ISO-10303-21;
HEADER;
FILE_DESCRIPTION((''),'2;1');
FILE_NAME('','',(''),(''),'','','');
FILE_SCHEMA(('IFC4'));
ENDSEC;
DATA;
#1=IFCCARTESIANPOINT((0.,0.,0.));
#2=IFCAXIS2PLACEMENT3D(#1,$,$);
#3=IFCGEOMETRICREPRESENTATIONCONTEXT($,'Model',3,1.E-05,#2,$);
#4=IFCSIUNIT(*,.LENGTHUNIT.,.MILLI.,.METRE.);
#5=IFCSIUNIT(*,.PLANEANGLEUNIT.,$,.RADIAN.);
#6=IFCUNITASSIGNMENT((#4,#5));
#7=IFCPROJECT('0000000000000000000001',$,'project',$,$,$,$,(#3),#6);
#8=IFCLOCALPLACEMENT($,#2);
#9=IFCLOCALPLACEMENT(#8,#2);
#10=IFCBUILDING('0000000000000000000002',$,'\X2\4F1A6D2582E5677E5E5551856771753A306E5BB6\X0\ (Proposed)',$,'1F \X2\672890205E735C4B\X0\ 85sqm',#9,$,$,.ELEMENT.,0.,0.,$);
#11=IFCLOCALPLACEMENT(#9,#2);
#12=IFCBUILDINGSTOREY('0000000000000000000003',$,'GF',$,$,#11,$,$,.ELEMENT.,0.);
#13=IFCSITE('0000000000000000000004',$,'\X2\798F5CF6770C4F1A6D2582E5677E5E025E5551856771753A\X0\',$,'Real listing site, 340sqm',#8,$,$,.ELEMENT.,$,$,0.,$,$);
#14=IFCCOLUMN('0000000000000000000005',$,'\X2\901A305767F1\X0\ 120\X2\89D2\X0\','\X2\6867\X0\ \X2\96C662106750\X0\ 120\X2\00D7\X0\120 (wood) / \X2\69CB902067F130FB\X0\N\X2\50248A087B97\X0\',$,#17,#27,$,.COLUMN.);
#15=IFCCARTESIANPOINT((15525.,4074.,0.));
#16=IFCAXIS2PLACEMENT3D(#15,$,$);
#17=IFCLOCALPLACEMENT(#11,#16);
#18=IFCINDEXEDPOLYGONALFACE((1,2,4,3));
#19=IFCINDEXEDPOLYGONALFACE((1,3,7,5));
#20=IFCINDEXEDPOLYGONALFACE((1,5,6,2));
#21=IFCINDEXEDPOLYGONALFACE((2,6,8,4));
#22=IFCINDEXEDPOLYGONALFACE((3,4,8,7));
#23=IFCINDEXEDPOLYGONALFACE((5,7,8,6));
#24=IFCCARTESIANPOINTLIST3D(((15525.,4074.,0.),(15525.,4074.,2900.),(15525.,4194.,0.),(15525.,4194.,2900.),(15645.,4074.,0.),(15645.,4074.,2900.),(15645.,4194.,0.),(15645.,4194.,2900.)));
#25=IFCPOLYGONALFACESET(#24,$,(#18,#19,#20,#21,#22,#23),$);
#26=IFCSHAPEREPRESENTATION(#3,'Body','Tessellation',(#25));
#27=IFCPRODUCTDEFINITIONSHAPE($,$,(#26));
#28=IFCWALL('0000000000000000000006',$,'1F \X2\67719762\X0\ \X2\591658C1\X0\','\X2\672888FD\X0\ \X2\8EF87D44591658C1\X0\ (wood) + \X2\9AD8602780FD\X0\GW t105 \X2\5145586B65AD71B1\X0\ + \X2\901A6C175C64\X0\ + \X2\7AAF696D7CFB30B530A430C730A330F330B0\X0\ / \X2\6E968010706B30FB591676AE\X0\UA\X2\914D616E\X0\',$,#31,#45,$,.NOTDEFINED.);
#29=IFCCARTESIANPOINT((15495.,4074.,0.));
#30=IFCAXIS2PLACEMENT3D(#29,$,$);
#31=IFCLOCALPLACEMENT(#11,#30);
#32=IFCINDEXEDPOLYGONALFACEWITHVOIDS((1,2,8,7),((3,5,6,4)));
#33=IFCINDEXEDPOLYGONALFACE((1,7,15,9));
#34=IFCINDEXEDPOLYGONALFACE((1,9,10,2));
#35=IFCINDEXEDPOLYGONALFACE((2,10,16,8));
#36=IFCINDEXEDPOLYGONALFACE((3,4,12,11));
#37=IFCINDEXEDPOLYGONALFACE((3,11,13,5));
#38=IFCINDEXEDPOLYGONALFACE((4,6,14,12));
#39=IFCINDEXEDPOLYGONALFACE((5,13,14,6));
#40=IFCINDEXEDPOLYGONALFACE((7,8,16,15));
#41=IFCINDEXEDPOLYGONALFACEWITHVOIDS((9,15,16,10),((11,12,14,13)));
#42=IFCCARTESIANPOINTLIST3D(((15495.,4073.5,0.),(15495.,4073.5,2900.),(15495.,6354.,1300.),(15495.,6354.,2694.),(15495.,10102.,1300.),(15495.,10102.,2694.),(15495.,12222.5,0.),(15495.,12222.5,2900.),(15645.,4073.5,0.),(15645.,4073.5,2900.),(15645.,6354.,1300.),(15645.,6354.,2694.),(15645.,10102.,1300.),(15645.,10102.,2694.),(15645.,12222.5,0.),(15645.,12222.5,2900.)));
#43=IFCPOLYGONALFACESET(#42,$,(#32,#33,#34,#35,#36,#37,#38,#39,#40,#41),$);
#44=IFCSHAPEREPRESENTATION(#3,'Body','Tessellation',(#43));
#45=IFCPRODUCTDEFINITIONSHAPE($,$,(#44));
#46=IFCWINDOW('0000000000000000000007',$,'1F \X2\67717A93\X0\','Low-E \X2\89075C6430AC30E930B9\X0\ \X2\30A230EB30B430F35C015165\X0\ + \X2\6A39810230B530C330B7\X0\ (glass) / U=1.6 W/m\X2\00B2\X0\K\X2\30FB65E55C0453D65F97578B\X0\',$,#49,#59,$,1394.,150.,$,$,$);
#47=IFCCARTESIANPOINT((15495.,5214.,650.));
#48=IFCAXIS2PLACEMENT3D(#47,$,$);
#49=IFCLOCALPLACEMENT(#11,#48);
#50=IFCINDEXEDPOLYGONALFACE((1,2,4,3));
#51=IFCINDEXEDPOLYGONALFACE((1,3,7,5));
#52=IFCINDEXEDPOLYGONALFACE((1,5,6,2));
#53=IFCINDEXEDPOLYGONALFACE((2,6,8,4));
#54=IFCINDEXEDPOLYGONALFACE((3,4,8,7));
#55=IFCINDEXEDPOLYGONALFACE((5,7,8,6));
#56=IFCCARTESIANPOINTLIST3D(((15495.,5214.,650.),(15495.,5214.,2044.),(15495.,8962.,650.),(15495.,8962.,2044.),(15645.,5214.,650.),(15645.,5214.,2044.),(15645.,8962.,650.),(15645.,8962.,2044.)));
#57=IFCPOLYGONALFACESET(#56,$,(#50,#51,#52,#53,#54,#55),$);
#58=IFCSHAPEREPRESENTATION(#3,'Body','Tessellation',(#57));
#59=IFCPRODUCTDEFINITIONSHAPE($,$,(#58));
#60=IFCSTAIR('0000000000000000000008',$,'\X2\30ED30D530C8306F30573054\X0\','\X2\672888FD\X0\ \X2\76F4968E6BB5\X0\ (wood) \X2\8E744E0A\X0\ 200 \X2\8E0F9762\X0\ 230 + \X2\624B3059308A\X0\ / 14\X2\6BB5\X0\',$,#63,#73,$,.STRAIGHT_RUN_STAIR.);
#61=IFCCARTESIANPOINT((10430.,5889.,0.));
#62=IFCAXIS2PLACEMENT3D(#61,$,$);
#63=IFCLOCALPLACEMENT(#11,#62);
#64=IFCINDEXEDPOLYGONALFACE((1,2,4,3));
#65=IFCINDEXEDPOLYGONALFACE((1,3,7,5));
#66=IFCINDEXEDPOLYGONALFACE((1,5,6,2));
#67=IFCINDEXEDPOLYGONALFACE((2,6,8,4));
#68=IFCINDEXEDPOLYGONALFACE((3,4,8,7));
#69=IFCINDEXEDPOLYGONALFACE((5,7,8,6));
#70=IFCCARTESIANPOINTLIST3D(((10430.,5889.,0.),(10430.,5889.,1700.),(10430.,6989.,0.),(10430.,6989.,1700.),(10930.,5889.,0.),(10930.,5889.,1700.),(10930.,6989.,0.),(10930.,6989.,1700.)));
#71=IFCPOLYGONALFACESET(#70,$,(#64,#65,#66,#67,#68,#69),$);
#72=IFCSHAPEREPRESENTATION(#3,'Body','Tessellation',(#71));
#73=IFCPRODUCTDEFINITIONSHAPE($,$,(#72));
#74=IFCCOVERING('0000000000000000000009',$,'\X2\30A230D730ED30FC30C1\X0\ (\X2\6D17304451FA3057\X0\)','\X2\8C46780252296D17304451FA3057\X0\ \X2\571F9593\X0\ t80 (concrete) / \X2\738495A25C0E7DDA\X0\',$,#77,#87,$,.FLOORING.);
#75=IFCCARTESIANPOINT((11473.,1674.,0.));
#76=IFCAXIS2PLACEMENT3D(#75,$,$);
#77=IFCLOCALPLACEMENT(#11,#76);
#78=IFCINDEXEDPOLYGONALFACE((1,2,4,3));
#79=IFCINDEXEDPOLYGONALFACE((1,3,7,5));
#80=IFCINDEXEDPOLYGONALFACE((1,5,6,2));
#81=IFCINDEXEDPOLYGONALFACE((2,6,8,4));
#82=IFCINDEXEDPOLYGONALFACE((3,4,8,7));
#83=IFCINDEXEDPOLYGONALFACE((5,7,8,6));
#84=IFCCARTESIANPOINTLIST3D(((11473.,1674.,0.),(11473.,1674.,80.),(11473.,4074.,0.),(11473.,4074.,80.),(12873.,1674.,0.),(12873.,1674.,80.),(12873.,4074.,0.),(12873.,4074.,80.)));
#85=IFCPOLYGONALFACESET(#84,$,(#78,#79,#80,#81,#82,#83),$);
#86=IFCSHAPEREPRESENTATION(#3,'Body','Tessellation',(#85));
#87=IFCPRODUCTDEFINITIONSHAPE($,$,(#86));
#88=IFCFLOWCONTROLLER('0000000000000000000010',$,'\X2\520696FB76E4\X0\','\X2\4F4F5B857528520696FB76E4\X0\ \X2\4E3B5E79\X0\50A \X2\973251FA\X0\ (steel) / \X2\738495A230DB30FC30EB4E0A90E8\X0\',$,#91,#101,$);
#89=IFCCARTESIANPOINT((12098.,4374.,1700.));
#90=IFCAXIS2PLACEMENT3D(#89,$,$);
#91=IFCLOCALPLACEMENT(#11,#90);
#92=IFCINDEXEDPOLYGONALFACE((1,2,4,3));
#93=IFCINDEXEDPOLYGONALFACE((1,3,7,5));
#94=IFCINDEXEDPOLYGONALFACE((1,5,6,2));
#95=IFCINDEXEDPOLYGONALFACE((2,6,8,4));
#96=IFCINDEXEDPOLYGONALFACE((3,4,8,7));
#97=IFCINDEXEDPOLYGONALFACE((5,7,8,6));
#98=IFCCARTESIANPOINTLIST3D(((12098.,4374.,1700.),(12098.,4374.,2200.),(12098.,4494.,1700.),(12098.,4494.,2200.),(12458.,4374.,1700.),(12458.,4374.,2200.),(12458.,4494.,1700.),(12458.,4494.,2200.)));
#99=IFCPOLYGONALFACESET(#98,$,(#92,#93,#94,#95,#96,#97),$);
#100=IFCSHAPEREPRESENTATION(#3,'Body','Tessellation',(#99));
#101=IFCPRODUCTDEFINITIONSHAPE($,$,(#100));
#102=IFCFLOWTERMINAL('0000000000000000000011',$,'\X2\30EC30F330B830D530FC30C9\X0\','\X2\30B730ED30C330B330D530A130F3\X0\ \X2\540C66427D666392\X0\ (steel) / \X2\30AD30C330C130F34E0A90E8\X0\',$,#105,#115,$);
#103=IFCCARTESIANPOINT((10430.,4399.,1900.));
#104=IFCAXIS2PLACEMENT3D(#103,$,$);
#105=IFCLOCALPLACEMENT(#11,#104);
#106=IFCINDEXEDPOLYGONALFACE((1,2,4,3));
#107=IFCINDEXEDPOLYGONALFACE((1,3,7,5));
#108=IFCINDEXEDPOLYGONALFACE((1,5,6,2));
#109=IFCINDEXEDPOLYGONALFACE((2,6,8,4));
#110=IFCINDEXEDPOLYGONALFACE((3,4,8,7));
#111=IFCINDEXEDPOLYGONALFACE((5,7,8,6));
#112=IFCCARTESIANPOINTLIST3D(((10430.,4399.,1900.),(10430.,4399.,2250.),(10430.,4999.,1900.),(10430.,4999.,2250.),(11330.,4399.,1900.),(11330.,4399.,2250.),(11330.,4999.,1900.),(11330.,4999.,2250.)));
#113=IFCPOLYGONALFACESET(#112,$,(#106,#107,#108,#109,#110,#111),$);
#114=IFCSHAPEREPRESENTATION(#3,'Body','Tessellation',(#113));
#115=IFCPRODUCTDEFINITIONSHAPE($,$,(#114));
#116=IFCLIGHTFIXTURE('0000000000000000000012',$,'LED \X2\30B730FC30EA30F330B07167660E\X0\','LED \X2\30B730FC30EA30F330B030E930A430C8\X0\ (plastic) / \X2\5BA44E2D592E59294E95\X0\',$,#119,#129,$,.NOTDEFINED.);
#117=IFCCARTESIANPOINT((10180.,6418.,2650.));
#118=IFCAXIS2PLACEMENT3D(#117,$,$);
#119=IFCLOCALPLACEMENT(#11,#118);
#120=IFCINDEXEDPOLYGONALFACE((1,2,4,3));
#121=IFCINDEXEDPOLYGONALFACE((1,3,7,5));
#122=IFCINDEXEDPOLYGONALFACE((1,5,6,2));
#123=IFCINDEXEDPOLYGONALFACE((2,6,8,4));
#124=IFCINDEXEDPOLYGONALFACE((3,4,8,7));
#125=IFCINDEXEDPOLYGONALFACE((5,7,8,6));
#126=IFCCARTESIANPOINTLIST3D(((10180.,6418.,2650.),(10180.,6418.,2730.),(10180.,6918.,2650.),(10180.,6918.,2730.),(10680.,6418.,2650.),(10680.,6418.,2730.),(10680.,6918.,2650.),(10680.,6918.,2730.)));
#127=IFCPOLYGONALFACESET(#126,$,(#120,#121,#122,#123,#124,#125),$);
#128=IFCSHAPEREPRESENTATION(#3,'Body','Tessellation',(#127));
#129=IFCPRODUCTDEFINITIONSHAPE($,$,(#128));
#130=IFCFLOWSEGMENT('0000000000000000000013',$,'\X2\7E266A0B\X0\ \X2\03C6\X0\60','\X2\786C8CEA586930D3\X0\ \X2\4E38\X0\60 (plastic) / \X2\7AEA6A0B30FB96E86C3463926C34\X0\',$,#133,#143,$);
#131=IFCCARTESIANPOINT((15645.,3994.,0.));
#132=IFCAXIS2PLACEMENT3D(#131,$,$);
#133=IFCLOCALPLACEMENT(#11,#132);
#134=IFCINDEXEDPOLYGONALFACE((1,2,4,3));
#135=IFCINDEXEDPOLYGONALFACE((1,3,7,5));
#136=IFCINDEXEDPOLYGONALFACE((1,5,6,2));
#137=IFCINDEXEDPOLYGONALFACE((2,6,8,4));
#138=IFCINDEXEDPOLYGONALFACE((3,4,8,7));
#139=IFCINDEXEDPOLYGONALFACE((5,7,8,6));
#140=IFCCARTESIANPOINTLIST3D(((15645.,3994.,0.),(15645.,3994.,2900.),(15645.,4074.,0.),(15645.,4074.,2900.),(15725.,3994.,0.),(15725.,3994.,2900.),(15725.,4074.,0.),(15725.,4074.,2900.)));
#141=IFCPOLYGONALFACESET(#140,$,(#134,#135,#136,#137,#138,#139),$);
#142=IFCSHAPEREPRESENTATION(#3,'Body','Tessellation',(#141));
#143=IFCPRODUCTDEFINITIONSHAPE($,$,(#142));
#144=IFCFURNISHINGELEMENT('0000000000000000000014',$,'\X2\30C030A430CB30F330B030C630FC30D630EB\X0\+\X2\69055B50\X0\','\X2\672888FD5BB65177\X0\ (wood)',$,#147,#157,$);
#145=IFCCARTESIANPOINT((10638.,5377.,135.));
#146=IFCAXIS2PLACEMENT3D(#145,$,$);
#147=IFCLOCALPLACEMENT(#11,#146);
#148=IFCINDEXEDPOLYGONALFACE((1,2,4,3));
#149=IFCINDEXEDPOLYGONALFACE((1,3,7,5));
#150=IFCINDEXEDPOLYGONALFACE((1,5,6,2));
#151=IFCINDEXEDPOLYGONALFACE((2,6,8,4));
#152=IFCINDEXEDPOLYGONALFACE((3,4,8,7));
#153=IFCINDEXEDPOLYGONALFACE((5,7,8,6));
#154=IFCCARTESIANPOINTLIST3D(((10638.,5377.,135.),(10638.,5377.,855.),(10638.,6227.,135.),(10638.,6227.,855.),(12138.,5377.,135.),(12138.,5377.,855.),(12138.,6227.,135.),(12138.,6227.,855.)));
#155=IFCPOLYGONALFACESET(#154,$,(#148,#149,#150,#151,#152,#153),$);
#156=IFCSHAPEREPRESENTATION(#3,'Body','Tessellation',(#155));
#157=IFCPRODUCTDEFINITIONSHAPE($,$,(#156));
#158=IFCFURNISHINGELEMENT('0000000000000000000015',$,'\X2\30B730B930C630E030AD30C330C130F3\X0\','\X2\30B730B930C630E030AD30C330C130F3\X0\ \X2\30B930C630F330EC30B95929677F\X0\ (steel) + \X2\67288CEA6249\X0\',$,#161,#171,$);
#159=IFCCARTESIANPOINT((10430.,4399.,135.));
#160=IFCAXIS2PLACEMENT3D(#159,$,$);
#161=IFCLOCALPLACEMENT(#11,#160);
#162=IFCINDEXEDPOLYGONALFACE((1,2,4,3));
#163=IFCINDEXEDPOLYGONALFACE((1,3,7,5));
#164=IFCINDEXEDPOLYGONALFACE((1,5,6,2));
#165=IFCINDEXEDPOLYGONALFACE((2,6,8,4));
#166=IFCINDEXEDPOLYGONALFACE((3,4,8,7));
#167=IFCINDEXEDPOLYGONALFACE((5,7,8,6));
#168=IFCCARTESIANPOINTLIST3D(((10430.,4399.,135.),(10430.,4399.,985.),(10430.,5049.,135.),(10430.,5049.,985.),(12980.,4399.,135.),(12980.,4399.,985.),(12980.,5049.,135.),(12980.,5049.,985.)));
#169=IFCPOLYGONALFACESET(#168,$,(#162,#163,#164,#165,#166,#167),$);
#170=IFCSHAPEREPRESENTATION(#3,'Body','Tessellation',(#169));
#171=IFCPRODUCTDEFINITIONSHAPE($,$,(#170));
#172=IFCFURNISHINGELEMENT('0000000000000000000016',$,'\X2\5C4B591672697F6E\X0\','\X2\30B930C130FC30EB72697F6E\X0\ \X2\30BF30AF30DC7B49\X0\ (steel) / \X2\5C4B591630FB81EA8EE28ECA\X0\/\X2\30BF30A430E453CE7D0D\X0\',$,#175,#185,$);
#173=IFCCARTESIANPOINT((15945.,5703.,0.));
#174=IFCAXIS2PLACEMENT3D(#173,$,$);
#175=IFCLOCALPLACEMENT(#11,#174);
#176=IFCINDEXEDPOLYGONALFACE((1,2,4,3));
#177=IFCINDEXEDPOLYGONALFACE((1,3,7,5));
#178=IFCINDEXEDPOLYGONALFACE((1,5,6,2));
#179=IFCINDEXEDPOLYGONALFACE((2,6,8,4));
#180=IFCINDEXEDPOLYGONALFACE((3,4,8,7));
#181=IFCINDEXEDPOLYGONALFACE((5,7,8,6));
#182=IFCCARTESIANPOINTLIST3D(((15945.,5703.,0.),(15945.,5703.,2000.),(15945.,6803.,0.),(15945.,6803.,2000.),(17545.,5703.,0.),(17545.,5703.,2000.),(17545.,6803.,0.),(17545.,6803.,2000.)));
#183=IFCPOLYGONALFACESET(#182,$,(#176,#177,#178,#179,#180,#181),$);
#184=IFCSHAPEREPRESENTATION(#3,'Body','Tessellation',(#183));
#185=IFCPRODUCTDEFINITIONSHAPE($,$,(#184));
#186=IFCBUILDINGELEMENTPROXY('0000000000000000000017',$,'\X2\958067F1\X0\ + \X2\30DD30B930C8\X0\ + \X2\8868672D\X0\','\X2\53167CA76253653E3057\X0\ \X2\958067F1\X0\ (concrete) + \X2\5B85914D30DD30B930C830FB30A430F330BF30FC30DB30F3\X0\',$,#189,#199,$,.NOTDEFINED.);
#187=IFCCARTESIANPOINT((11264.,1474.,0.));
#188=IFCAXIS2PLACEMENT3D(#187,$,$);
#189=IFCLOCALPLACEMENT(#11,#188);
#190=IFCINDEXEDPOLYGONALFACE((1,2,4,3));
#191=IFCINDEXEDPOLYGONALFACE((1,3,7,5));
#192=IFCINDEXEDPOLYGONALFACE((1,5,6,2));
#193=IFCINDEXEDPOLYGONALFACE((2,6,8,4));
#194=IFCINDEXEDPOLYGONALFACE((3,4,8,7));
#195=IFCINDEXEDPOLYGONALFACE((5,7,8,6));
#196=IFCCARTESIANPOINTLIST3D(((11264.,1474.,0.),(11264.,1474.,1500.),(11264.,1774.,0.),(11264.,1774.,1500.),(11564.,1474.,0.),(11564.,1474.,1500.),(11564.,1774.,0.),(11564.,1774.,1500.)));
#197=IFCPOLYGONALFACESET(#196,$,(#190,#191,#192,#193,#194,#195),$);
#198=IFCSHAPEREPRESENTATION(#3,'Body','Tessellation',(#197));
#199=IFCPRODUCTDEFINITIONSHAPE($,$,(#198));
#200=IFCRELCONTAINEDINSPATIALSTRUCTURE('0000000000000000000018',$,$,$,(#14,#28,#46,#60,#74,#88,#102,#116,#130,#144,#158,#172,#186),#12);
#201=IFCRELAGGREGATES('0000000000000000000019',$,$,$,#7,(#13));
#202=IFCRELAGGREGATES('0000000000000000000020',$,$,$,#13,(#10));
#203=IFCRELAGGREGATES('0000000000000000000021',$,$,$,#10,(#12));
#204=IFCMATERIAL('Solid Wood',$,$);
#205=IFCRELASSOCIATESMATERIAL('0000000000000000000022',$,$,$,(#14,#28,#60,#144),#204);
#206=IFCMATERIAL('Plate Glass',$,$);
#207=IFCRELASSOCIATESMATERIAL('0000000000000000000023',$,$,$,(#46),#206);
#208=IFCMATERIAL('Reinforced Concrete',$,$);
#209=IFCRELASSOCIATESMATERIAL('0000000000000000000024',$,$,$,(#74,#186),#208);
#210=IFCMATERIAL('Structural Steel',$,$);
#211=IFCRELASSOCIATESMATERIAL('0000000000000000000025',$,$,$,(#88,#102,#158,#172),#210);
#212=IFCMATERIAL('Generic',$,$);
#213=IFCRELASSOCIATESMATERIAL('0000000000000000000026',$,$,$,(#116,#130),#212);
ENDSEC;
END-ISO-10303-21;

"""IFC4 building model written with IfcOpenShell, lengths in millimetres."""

from ifc_helpers import new_model, si_unit, frame, frame_2d, origin, place, context, project, spatial, rectangle, extrude, material, element, fill, save


model = new_model("IFC4")

# Units and contexts
model_context = context("Model", 3, precision=1e-05, world=origin())
ifc_project = project(units=[si_unit("LENGTHUNIT", "METRE", prefix="MILLI"), si_unit("PLANEANGLEUNIT", "RADIAN")], contexts=[model_context])

# Site, building, storey
site_placement = place(None, origin())
site = spatial("IfcSite", under=ifc_project, at=site_placement, Name="福島県会津若松市幕内東町", ObjectType="Real listing site, 340sqm", CompositionType="ELEMENT", RefElevation=0.0)
building_placement = place(site_placement, origin())
building = spatial("IfcBuilding", under=site, at=building_placement, Name="会津若松幕内東町の家 (Proposed)", ObjectType="1F 木造平屋 85sqm", CompositionType="ELEMENT", ElevationOfRefHeight=0.0, ElevationOfTerrain=0.0)
storey_placement = place(building_placement, origin())
storey = spatial("IfcBuildingStorey", under=building, at=storey_placement, Name="GF", CompositionType="ELEMENT", Elevation=0.0)

# Column
ifc_material_1 = material(Name="Solid Wood")
column_1_placement = place(storey_placement, frame((15525.0, 4074.0, 0.0)))
element("IfcColumn", 1, at=column_1_placement, inside=storey, material=ifc_material_1, Name="通し柱 120角", Description="桧 集成材 120×120 (wood) / 構造柱・N値計算", PredefinedType="COLUMN", context=model_context, shape_type="SweptSolid", body=[
    extrude(rectangle(XDim=120.0, YDim=120.0, at=frame_2d((60.0, 60.0))), frame((15525.0, 4074.0, 0.0)), (0.0, 0.0, 1.0), 2900.0),
])

# Wall, opening, window
wall_1_placement = place(storey_placement, frame((15495.0, 4074.0, 0.0)))
wall_1 = element("IfcWall", 2, at=wall_1_placement, inside=storey, material=ifc_material_1, Name="1F 東面 外壁", Description="木製 軸組外壁 (wood) + 高性能GW t105 充填断熱 + 通気層 + 窯業系サイディング / 準耐火・外皮UA配慮", PredefinedType="NOTDEFINED", context=model_context, shape_type="SweptSolid", body=[
    extrude(rectangle(XDim=150.0, YDim=8149.0, at=frame_2d((75.0, 4074.0))), frame((15495.0, 4074.0, 0.0)), (0.0, 0.0, 1.0), 2900.0),
])
opening_placement = place(storey_placement, frame((15495.0, 5214.0, 650.0)))
opening = element("IfcOpeningElement", 3, at=opening_placement, cuts=wall_1, PredefinedType="NOTDEFINED", context=model_context, shape_type="SweptSolid", body=[
    extrude(rectangle(XDim=150.0, YDim=3748.0, at=frame_2d((75.0, 1874.0))), frame((15495.0, 5214.0, 650.0)), (0.0, 0.0, 1.0), 1394.0),
])
ifc_material_2 = material(Name="Plate Glass")
window_placement = place(storey_placement, frame((15495.0, 5214.0, 650.0)))
window = element("IfcWindow", 4, at=window_placement, inside=storey, material=ifc_material_2, Name="1F 東窓", Description="Low-E 複層ガラス アルゴン封入 + 樹脂サッシ (glass) / U=1.6 W/m²K・日射取得型", OverallHeight=1394.0, OverallWidth=150.0, context=model_context, shape_type="SweptSolid", body=[
    extrude(rectangle(XDim=150.0, YDim=3748.0, at=frame_2d((75.0, 1874.0))), frame((15495.0, 5214.0, 650.0)), (0.0, 0.0, 1.0), 1394.0),
])
fill(opening, window)

# Stair
stair_placement = place(storey_placement, frame((10430.0, 5889.0, 0.0)))
element("IfcStair", 5, at=stair_placement, inside=storey, material=ifc_material_1, Name="ロフトはしご", Description="木製 直階段 (wood) 蹴上 200 踏面 230 + 手すり / 14段", PredefinedType="STRAIGHT_RUN_STAIR", context=model_context, shape_type="SweptSolid", body=[
    extrude(rectangle(XDim=500.0, YDim=1100.0, at=frame_2d((250.0, 550.0))), frame((10430.0, 5889.0, 0.0)), (0.0, 0.0, 1.0), 1700.0),
])

# Covering
ifc_material_3 = material(Name="Reinforced Concrete")
covering_placement = place(storey_placement, frame((11473.0, 1674.0, 0.0)))
element("IfcCovering", 6, at=covering_placement, inside=storey, material=ifc_material_3, Name="アプローチ (洗い出し)", Description="豆砂利洗い出し 土間 t80 (concrete) / 玄関導線", PredefinedType="FLOORING", context=model_context, shape_type="SweptSolid", body=[
    extrude(rectangle(XDim=1400.0, YDim=2400.0, at=frame_2d((700.0, 1200.0))), frame((11473.0, 1674.0, 0.0)), (0.0, 0.0, 1.0), 80.0),
])

# Flow controller
ifc_material_4 = material(Name="Structural Steel")
flow_controller_placement = place(storey_placement, frame((12098.0, 4374.0, 1700.0)))
element("IfcFlowController", 7, at=flow_controller_placement, inside=storey, material=ifc_material_4, Name="分電盤", Description="住宅用分電盤 主幹50A 露出 (steel) / 玄関ホール上部", context=model_context, shape_type="SweptSolid", body=[
    extrude(rectangle(XDim=360.0, YDim=120.0, at=frame_2d((180.0, 60.0))), frame((12098.0, 4374.0, 1700.0)), (0.0, 0.0, 1.0), 500.0),
])

# Flow terminal
flow_terminal_placement = place(storey_placement, frame((10430.0, 4399.0, 1900.0)))
element("IfcFlowTerminal", 8, at=flow_terminal_placement, inside=storey, material=ifc_material_4, Name="レンジフード", Description="シロッコファン 同時給排 (steel) / キッチン上部", context=model_context, shape_type="SweptSolid", body=[
    extrude(rectangle(XDim=900.0, YDim=600.0, at=frame_2d((450.0, 300.0))), frame((10430.0, 4399.0, 1900.0)), (0.0, 0.0, 1.0), 350.0),
])

# Light fixture
ifc_material_5 = material(Name="Generic")
light_fixture_placement = place(storey_placement, frame((10180.0, 6418.0, 2650.0)))
element("IfcLightFixture", 9, at=light_fixture_placement, inside=storey, material=ifc_material_5, Name="LED シーリング照明", Description="LED シーリングライト (plastic) / 室中央天井", PredefinedType="NOTDEFINED", context=model_context, shape_type="SweptSolid", body=[
    extrude(rectangle(XDim=500.0, YDim=500.0, at=frame_2d((250.0, 250.0))), frame((10180.0, 6418.0, 2650.0)), (0.0, 0.0, 1.0), 80.0),
])

# Flow segment
flow_segment_placement = place(storey_placement, frame((15645.0, 3994.0, 0.0)))
element("IfcFlowSegment", 10, at=flow_segment_placement, inside=storey, material=ifc_material_5, Name="縦樋 φ60", Description="硬質塩ビ 丸60 (plastic) / 竪樋・雨水排水", context=model_context, shape_type="SweptSolid", body=[
    extrude(rectangle(XDim=80.0, YDim=80.0, at=frame_2d((40.0, 40.0))), frame((15645.0, 3994.0, 0.0)), (0.0, 0.0, 1.0), 2900.0),
])

# Furnishing elements
furnishing_1_placement = place(storey_placement, frame((10638.0, 5377.0, 135.0)))
element("IfcFurnishingElement", 11, at=furnishing_1_placement, inside=storey, material=ifc_material_1, Name="ダイニングテーブル+椅子", Description="木製家具 (wood)", context=model_context, shape_type="SweptSolid", body=[
    extrude(rectangle(XDim=1500.0, YDim=850.0, at=frame_2d((750.0, 425.0))), frame((10638.0, 5377.0, 135.0)), (0.0, 0.0, 1.0), 720.0),
])
furnishing_2_placement = place(storey_placement, frame((10430.0, 4399.0, 135.0)))
element("IfcFurnishingElement", 12, at=furnishing_2_placement, inside=storey, material=ifc_material_4, Name="システムキッチン", Description="システムキッチン ステンレス天板 (steel) + 木質扉", context=model_context, shape_type="SweptSolid", body=[
    extrude(rectangle(XDim=2550.0, YDim=650.0, at=frame_2d((1275.0, 325.0))), frame((10430.0, 4399.0, 135.0)), (0.0, 0.0, 1.0), 850.0),
])
furnishing_3_placement = place(storey_placement, frame((15945.0, 5703.0, 0.0)))
element("IfcFurnishingElement", 13, at=furnishing_3_placement, inside=storey, material=ifc_material_4, Name="屋外物置", Description="スチール物置 タクボ等 (steel) / 屋外・自転車/タイヤ収納", context=model_context, shape_type="SweptSolid", body=[
    extrude(rectangle(XDim=1600.0, YDim=1100.0, at=frame_2d((800.0, 550.0))), frame((15945.0, 5703.0, 0.0)), (0.0, 0.0, 1.0), 2000.0),
])

# Building element proxy
proxy_placement = place(storey_placement, frame((11264.0, 1474.0, 0.0)))
element("IfcBuildingElementProxy", 14, at=proxy_placement, inside=storey, material=ifc_material_3, Name="門柱 + ポスト + 表札", Description="化粧打放し 門柱 (concrete) + 宅配ポスト・インターホン", PredefinedType="NOTDEFINED", context=model_context, shape_type="SweptSolid", body=[
    extrude(rectangle(XDim=300.0, YDim=300.0, at=frame_2d((150.0, 150.0))), frame((11264.0, 1474.0, 0.0)), (0.0, 0.0, 1.0), 1500.0),
])

save(model, "model.ifc")
